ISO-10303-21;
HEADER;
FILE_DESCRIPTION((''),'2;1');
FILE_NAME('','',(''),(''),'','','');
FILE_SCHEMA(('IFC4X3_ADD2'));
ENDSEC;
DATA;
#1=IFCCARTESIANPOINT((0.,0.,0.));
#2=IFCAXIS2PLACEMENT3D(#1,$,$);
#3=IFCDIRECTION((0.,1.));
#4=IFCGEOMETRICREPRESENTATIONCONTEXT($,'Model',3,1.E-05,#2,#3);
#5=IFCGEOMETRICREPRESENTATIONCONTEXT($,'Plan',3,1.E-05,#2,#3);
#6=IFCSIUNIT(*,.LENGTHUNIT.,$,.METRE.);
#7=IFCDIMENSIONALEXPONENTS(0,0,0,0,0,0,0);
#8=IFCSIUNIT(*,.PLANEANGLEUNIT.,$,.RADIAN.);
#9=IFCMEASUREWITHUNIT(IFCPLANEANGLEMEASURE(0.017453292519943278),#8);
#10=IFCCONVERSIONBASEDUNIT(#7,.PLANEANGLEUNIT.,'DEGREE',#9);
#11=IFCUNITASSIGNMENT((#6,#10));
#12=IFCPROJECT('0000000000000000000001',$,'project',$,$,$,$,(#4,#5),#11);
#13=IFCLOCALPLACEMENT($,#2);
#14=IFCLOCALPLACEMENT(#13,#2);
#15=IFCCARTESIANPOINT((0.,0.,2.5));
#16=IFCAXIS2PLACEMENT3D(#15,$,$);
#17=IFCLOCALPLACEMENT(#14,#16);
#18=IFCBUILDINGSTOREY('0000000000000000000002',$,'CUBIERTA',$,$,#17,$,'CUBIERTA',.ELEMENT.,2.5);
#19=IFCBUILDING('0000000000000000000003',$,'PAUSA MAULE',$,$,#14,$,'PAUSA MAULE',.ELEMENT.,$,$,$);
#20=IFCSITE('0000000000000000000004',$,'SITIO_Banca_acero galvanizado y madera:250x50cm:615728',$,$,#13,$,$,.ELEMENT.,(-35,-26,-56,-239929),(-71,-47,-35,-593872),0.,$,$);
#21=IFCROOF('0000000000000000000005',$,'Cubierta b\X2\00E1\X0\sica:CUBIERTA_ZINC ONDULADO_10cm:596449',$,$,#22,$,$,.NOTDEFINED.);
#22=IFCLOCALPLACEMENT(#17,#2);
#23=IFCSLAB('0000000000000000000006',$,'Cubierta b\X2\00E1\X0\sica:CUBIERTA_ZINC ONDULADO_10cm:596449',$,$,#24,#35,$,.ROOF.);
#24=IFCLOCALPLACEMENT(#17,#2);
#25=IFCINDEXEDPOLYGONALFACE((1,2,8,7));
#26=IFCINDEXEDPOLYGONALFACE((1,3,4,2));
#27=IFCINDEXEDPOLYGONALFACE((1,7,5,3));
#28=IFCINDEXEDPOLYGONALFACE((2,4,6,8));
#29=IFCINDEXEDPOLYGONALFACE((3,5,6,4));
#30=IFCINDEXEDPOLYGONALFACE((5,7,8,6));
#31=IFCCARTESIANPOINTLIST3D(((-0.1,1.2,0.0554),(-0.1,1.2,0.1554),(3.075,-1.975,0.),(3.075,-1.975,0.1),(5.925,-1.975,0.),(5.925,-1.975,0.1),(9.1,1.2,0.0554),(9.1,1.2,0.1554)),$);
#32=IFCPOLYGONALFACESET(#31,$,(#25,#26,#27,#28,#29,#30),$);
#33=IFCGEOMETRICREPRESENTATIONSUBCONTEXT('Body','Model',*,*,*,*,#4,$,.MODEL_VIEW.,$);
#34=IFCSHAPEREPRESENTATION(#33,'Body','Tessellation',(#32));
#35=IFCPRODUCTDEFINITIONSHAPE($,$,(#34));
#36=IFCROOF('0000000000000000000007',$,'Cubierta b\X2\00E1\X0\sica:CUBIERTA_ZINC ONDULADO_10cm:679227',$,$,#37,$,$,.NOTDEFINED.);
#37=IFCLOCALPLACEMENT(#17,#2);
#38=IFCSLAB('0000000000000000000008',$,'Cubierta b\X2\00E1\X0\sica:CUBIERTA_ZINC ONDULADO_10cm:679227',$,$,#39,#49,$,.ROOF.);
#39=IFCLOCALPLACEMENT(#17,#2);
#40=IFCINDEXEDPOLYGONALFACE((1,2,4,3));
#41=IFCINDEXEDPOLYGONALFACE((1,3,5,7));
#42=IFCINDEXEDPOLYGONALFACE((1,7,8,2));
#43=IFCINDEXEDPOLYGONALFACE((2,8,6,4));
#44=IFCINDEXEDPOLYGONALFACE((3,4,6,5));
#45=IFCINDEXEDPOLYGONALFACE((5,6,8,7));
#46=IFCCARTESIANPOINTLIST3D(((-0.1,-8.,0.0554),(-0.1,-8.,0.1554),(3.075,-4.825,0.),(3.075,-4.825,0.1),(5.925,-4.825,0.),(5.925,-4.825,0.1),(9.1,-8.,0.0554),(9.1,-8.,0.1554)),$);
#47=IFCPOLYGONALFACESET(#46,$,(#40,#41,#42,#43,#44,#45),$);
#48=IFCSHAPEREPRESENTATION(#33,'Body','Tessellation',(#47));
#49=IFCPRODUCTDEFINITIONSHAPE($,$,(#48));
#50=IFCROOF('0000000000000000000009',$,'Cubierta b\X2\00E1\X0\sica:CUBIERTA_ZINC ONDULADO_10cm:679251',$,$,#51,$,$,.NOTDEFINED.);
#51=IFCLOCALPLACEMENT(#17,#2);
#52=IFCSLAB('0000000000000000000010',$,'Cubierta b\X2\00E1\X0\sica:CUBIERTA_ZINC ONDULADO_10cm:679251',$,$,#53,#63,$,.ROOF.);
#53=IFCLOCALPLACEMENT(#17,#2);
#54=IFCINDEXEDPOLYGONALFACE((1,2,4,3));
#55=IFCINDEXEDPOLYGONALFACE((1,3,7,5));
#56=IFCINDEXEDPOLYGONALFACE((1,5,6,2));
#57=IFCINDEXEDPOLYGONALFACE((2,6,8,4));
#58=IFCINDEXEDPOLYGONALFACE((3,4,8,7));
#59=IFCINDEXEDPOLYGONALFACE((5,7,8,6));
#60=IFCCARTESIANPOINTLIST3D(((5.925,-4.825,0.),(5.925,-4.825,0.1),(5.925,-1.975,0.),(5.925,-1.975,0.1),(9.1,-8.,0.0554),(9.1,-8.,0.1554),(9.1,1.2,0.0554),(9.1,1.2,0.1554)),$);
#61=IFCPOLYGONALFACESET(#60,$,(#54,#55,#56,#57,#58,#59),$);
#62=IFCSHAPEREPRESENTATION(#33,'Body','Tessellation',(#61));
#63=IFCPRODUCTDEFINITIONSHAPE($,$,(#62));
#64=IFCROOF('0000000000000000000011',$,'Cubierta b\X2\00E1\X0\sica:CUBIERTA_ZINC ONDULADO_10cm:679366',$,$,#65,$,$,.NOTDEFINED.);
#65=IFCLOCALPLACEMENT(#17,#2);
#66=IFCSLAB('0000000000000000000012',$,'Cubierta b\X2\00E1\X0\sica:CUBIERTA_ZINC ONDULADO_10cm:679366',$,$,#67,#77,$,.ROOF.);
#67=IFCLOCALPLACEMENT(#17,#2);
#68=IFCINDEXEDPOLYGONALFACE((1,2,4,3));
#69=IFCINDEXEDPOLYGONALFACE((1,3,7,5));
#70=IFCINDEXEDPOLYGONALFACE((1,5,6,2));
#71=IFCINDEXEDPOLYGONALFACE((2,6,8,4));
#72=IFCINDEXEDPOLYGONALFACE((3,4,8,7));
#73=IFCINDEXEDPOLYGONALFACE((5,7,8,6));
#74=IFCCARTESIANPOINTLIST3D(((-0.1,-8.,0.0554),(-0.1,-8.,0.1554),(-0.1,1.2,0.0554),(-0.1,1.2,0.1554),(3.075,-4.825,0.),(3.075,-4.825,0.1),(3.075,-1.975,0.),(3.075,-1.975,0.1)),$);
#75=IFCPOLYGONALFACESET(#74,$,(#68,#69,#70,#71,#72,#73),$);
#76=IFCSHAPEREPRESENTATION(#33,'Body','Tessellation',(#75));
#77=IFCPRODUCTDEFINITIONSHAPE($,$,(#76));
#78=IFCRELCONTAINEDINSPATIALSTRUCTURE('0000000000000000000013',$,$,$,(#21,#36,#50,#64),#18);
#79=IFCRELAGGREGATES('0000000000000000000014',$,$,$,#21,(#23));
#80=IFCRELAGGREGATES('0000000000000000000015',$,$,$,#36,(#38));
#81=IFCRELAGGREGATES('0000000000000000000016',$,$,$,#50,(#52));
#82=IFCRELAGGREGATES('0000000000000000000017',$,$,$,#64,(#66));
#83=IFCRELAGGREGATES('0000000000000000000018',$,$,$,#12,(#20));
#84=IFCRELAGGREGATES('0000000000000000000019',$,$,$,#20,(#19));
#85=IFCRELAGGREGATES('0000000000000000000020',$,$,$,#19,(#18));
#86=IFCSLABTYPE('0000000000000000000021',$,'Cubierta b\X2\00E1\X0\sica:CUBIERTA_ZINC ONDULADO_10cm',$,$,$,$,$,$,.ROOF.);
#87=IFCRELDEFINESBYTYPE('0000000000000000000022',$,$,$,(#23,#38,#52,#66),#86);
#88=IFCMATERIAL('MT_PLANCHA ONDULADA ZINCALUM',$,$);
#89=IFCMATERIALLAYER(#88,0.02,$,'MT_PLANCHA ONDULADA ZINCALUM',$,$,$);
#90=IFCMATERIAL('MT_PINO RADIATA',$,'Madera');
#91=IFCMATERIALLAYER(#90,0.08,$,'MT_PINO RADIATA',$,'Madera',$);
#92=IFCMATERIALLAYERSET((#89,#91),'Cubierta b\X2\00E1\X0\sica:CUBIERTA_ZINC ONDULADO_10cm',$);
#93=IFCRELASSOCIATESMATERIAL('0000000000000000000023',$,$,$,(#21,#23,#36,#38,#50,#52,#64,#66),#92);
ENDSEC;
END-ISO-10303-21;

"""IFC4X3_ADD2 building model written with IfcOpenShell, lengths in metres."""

from ifc_helpers import new_model, entity, si_unit, converted_unit, direction, frame, origin, place, context, subcontext, project, spatial, polyline, outline, extrude, material, layer, layer_set, type_object, element, aggregate, save


model = new_model("IFC4X3_ADD2")

# Units and contexts
model_context = context("Model", 3, precision=1e-05, world=origin(), true_north=direction((0.0, 1.0)))
plan_context = context("Plan", 3, precision=1e-05, world=origin(), true_north=direction((0.0, 1.0)))
body_context = subcontext(model_context, "Body", "Model", "MODEL_VIEW")
ifc_project = project(units=[si_unit("LENGTHUNIT", "METRE"), converted_unit("PLANEANGLEUNIT", "DEGREE", entity("IfcPlaneAngleMeasure", 0.017453292519943278), si_unit("PLANEANGLEUNIT", "RADIAN"), dimensions=[0, 0, 0, 0, 0, 0, 0])], contexts=[model_context, plan_context])

# Site, building, storey
site_placement = place(None, origin())
site = spatial("IfcSite", under=ifc_project, at=site_placement, Name="SITIO_Banca_acero galvanizado y madera:250x50cm:615728", CompositionType="ELEMENT", RefLatitude=(-35, -26, -56, -239929), RefLongitude=(-71, -47, -35, -593872), RefElevation=0.0)
building_placement = place(site_placement, origin())
building = spatial("IfcBuilding", under=site, at=building_placement, Name="PAUSA MAULE", LongName="PAUSA MAULE", CompositionType="ELEMENT")
storey_placement = place(building_placement, frame((0.0, 0.0, 2.5)))
storey = spatial("IfcBuildingStorey", under=building, at=storey_placement, Name="CUBIERTA", LongName="CUBIERTA", CompositionType="ELEMENT", Elevation=2.5)

# Shared definitions
ifc_material_1 = material(Name="MT_PINO RADIATA", Category="Madera")

# Roofs, slabs
ifc_material_2 = material(Name="MT_PLANCHA ONDULADA ZINCALUM")
ifc_layer_1 = layer(ifc_material_2, 0.02, Name="MT_PLANCHA ONDULADA ZINCALUM")
ifc_layer_2 = layer(ifc_material_1, 0.08, Name="MT_PINO RADIATA", Category="Madera")
ifc_layer_set = layer_set([ifc_layer_1, ifc_layer_2], Name="Cubierta básica:CUBIERTA_ZINC ONDULADO_10cm")
roof_1_placement = place(storey_placement, frame((-0.1, -1.975, 0.0)))
roof_1 = element("IfcRoof", 1, at=roof_1_placement, inside=storey, material=ifc_layer_set, Name="Cubierta básica:CUBIERTA_ZINC ONDULADO_10cm:596449", PredefinedType="NOTDEFINED")
slab_type = type_object("IfcSlabType", Name="Cubierta básica:CUBIERTA_ZINC ONDULADO_10cm", PredefinedType="ROOF")
slab_1_placement = place(roof_1_placement, origin())
slab_1 = element("IfcSlab", 2, at=slab_1_placement, type_object=slab_type, material=ifc_layer_set, Name="Cubierta básica:CUBIERTA_ZINC ONDULADO_10cm:596449", PredefinedType="ROOF", context=body_context, shape_type="SweptSolid", body=[
    extrude(outline(polyline([(-4.6, 1.5877), (-1.425, -1.5877), (1.425, -1.5877), (4.6, 1.5877), (-4.6, 1.5877)])), frame((4.6, 1.5875, 0.0277), z_axis=(0.0, -0.017452, 0.999848), x_axis=(1.0, 0.0, 0.0)), (0.0, 0.017452, 0.999848), 0.1),
])
aggregate(roof_1, [slab_1])
roof_2_placement = place(storey_placement, frame((-0.1, -8.0, 0.0)))
roof_2 = element("IfcRoof", 3, at=roof_2_placement, inside=storey, material=ifc_layer_set, Name="Cubierta básica:CUBIERTA_ZINC ONDULADO_10cm:679227", PredefinedType="NOTDEFINED")
slab_2_placement = place(roof_2_placement, origin())
slab_2 = element("IfcSlab", 4, at=slab_2_placement, type_object=slab_type, material=ifc_layer_set, Name="Cubierta básica:CUBIERTA_ZINC ONDULADO_10cm:679227", PredefinedType="ROOF", context=body_context, shape_type="SweptSolid", body=[
    extrude(outline(polyline([(4.6, -1.5877), (1.425, 1.5877), (-1.425, 1.5877), (-4.6, -1.5877), (4.6, -1.5877)])), frame((4.6, 1.5875, 0.0277), z_axis=(0.0, 0.017452, 0.999848), x_axis=(1.0, 0.0, 0.0)), (0.0, -0.017452, 0.999848), 0.1),
])
aggregate(roof_2, [slab_2])
roof_3_placement = place(storey_placement, frame((5.925, -8.0, 0.0)))
roof_3 = element("IfcRoof", 5, at=roof_3_placement, inside=storey, material=ifc_layer_set, Name="Cubierta básica:CUBIERTA_ZINC ONDULADO_10cm:679251", PredefinedType="NOTDEFINED")
slab_3_placement = place(roof_3_placement, origin())
slab_3 = element("IfcSlab", 6, at=slab_3_placement, type_object=slab_type, material=ifc_layer_set, Name="Cubierta básica:CUBIERTA_ZINC ONDULADO_10cm:679251", PredefinedType="ROOF", context=body_context, shape_type="SweptSolid", body=[
    extrude(outline(polyline([(1.5877, 4.6), (-1.5877, 1.425), (-1.5877, -1.425), (1.5877, -4.6), (1.5877, 4.6)])), frame((1.5875, 4.6, 0.0277), z_axis=(-0.017452, 0.0, 0.999848), x_axis=(0.999848, 0.0, 0.017452)), (0.017452, 0.0, 0.999848), 0.1),
])
aggregate(roof_3, [slab_3])
roof_4_placement = place(storey_placement, frame((-0.1, -8.0, 0.0)))
roof_4 = element("IfcRoof", 7, at=roof_4_placement, inside=storey, material=ifc_layer_set, Name="Cubierta básica:CUBIERTA_ZINC ONDULADO_10cm:679366", PredefinedType="NOTDEFINED")
slab_4_placement = place(roof_4_placement, origin())
slab_4 = element("IfcSlab", 8, at=slab_4_placement, type_object=slab_type, material=ifc_layer_set, Name="Cubierta básica:CUBIERTA_ZINC ONDULADO_10cm:679366", PredefinedType="ROOF", context=body_context, shape_type="SweptSolid", body=[
    extrude(outline(polyline([(-1.5877, -4.6), (1.5877, -1.425), (1.5877, 1.425), (-1.5877, 4.6), (-1.5877, -4.6)])), frame((1.5875, 4.6, 0.0277), z_axis=(0.017452, 0.0, 0.999848), x_axis=(0.999848, 0.0, -0.017452)), (-0.017452, 0.0, 0.999848), 0.1),
])
aggregate(roof_4, [slab_4])

save(model, "model.ifc")
